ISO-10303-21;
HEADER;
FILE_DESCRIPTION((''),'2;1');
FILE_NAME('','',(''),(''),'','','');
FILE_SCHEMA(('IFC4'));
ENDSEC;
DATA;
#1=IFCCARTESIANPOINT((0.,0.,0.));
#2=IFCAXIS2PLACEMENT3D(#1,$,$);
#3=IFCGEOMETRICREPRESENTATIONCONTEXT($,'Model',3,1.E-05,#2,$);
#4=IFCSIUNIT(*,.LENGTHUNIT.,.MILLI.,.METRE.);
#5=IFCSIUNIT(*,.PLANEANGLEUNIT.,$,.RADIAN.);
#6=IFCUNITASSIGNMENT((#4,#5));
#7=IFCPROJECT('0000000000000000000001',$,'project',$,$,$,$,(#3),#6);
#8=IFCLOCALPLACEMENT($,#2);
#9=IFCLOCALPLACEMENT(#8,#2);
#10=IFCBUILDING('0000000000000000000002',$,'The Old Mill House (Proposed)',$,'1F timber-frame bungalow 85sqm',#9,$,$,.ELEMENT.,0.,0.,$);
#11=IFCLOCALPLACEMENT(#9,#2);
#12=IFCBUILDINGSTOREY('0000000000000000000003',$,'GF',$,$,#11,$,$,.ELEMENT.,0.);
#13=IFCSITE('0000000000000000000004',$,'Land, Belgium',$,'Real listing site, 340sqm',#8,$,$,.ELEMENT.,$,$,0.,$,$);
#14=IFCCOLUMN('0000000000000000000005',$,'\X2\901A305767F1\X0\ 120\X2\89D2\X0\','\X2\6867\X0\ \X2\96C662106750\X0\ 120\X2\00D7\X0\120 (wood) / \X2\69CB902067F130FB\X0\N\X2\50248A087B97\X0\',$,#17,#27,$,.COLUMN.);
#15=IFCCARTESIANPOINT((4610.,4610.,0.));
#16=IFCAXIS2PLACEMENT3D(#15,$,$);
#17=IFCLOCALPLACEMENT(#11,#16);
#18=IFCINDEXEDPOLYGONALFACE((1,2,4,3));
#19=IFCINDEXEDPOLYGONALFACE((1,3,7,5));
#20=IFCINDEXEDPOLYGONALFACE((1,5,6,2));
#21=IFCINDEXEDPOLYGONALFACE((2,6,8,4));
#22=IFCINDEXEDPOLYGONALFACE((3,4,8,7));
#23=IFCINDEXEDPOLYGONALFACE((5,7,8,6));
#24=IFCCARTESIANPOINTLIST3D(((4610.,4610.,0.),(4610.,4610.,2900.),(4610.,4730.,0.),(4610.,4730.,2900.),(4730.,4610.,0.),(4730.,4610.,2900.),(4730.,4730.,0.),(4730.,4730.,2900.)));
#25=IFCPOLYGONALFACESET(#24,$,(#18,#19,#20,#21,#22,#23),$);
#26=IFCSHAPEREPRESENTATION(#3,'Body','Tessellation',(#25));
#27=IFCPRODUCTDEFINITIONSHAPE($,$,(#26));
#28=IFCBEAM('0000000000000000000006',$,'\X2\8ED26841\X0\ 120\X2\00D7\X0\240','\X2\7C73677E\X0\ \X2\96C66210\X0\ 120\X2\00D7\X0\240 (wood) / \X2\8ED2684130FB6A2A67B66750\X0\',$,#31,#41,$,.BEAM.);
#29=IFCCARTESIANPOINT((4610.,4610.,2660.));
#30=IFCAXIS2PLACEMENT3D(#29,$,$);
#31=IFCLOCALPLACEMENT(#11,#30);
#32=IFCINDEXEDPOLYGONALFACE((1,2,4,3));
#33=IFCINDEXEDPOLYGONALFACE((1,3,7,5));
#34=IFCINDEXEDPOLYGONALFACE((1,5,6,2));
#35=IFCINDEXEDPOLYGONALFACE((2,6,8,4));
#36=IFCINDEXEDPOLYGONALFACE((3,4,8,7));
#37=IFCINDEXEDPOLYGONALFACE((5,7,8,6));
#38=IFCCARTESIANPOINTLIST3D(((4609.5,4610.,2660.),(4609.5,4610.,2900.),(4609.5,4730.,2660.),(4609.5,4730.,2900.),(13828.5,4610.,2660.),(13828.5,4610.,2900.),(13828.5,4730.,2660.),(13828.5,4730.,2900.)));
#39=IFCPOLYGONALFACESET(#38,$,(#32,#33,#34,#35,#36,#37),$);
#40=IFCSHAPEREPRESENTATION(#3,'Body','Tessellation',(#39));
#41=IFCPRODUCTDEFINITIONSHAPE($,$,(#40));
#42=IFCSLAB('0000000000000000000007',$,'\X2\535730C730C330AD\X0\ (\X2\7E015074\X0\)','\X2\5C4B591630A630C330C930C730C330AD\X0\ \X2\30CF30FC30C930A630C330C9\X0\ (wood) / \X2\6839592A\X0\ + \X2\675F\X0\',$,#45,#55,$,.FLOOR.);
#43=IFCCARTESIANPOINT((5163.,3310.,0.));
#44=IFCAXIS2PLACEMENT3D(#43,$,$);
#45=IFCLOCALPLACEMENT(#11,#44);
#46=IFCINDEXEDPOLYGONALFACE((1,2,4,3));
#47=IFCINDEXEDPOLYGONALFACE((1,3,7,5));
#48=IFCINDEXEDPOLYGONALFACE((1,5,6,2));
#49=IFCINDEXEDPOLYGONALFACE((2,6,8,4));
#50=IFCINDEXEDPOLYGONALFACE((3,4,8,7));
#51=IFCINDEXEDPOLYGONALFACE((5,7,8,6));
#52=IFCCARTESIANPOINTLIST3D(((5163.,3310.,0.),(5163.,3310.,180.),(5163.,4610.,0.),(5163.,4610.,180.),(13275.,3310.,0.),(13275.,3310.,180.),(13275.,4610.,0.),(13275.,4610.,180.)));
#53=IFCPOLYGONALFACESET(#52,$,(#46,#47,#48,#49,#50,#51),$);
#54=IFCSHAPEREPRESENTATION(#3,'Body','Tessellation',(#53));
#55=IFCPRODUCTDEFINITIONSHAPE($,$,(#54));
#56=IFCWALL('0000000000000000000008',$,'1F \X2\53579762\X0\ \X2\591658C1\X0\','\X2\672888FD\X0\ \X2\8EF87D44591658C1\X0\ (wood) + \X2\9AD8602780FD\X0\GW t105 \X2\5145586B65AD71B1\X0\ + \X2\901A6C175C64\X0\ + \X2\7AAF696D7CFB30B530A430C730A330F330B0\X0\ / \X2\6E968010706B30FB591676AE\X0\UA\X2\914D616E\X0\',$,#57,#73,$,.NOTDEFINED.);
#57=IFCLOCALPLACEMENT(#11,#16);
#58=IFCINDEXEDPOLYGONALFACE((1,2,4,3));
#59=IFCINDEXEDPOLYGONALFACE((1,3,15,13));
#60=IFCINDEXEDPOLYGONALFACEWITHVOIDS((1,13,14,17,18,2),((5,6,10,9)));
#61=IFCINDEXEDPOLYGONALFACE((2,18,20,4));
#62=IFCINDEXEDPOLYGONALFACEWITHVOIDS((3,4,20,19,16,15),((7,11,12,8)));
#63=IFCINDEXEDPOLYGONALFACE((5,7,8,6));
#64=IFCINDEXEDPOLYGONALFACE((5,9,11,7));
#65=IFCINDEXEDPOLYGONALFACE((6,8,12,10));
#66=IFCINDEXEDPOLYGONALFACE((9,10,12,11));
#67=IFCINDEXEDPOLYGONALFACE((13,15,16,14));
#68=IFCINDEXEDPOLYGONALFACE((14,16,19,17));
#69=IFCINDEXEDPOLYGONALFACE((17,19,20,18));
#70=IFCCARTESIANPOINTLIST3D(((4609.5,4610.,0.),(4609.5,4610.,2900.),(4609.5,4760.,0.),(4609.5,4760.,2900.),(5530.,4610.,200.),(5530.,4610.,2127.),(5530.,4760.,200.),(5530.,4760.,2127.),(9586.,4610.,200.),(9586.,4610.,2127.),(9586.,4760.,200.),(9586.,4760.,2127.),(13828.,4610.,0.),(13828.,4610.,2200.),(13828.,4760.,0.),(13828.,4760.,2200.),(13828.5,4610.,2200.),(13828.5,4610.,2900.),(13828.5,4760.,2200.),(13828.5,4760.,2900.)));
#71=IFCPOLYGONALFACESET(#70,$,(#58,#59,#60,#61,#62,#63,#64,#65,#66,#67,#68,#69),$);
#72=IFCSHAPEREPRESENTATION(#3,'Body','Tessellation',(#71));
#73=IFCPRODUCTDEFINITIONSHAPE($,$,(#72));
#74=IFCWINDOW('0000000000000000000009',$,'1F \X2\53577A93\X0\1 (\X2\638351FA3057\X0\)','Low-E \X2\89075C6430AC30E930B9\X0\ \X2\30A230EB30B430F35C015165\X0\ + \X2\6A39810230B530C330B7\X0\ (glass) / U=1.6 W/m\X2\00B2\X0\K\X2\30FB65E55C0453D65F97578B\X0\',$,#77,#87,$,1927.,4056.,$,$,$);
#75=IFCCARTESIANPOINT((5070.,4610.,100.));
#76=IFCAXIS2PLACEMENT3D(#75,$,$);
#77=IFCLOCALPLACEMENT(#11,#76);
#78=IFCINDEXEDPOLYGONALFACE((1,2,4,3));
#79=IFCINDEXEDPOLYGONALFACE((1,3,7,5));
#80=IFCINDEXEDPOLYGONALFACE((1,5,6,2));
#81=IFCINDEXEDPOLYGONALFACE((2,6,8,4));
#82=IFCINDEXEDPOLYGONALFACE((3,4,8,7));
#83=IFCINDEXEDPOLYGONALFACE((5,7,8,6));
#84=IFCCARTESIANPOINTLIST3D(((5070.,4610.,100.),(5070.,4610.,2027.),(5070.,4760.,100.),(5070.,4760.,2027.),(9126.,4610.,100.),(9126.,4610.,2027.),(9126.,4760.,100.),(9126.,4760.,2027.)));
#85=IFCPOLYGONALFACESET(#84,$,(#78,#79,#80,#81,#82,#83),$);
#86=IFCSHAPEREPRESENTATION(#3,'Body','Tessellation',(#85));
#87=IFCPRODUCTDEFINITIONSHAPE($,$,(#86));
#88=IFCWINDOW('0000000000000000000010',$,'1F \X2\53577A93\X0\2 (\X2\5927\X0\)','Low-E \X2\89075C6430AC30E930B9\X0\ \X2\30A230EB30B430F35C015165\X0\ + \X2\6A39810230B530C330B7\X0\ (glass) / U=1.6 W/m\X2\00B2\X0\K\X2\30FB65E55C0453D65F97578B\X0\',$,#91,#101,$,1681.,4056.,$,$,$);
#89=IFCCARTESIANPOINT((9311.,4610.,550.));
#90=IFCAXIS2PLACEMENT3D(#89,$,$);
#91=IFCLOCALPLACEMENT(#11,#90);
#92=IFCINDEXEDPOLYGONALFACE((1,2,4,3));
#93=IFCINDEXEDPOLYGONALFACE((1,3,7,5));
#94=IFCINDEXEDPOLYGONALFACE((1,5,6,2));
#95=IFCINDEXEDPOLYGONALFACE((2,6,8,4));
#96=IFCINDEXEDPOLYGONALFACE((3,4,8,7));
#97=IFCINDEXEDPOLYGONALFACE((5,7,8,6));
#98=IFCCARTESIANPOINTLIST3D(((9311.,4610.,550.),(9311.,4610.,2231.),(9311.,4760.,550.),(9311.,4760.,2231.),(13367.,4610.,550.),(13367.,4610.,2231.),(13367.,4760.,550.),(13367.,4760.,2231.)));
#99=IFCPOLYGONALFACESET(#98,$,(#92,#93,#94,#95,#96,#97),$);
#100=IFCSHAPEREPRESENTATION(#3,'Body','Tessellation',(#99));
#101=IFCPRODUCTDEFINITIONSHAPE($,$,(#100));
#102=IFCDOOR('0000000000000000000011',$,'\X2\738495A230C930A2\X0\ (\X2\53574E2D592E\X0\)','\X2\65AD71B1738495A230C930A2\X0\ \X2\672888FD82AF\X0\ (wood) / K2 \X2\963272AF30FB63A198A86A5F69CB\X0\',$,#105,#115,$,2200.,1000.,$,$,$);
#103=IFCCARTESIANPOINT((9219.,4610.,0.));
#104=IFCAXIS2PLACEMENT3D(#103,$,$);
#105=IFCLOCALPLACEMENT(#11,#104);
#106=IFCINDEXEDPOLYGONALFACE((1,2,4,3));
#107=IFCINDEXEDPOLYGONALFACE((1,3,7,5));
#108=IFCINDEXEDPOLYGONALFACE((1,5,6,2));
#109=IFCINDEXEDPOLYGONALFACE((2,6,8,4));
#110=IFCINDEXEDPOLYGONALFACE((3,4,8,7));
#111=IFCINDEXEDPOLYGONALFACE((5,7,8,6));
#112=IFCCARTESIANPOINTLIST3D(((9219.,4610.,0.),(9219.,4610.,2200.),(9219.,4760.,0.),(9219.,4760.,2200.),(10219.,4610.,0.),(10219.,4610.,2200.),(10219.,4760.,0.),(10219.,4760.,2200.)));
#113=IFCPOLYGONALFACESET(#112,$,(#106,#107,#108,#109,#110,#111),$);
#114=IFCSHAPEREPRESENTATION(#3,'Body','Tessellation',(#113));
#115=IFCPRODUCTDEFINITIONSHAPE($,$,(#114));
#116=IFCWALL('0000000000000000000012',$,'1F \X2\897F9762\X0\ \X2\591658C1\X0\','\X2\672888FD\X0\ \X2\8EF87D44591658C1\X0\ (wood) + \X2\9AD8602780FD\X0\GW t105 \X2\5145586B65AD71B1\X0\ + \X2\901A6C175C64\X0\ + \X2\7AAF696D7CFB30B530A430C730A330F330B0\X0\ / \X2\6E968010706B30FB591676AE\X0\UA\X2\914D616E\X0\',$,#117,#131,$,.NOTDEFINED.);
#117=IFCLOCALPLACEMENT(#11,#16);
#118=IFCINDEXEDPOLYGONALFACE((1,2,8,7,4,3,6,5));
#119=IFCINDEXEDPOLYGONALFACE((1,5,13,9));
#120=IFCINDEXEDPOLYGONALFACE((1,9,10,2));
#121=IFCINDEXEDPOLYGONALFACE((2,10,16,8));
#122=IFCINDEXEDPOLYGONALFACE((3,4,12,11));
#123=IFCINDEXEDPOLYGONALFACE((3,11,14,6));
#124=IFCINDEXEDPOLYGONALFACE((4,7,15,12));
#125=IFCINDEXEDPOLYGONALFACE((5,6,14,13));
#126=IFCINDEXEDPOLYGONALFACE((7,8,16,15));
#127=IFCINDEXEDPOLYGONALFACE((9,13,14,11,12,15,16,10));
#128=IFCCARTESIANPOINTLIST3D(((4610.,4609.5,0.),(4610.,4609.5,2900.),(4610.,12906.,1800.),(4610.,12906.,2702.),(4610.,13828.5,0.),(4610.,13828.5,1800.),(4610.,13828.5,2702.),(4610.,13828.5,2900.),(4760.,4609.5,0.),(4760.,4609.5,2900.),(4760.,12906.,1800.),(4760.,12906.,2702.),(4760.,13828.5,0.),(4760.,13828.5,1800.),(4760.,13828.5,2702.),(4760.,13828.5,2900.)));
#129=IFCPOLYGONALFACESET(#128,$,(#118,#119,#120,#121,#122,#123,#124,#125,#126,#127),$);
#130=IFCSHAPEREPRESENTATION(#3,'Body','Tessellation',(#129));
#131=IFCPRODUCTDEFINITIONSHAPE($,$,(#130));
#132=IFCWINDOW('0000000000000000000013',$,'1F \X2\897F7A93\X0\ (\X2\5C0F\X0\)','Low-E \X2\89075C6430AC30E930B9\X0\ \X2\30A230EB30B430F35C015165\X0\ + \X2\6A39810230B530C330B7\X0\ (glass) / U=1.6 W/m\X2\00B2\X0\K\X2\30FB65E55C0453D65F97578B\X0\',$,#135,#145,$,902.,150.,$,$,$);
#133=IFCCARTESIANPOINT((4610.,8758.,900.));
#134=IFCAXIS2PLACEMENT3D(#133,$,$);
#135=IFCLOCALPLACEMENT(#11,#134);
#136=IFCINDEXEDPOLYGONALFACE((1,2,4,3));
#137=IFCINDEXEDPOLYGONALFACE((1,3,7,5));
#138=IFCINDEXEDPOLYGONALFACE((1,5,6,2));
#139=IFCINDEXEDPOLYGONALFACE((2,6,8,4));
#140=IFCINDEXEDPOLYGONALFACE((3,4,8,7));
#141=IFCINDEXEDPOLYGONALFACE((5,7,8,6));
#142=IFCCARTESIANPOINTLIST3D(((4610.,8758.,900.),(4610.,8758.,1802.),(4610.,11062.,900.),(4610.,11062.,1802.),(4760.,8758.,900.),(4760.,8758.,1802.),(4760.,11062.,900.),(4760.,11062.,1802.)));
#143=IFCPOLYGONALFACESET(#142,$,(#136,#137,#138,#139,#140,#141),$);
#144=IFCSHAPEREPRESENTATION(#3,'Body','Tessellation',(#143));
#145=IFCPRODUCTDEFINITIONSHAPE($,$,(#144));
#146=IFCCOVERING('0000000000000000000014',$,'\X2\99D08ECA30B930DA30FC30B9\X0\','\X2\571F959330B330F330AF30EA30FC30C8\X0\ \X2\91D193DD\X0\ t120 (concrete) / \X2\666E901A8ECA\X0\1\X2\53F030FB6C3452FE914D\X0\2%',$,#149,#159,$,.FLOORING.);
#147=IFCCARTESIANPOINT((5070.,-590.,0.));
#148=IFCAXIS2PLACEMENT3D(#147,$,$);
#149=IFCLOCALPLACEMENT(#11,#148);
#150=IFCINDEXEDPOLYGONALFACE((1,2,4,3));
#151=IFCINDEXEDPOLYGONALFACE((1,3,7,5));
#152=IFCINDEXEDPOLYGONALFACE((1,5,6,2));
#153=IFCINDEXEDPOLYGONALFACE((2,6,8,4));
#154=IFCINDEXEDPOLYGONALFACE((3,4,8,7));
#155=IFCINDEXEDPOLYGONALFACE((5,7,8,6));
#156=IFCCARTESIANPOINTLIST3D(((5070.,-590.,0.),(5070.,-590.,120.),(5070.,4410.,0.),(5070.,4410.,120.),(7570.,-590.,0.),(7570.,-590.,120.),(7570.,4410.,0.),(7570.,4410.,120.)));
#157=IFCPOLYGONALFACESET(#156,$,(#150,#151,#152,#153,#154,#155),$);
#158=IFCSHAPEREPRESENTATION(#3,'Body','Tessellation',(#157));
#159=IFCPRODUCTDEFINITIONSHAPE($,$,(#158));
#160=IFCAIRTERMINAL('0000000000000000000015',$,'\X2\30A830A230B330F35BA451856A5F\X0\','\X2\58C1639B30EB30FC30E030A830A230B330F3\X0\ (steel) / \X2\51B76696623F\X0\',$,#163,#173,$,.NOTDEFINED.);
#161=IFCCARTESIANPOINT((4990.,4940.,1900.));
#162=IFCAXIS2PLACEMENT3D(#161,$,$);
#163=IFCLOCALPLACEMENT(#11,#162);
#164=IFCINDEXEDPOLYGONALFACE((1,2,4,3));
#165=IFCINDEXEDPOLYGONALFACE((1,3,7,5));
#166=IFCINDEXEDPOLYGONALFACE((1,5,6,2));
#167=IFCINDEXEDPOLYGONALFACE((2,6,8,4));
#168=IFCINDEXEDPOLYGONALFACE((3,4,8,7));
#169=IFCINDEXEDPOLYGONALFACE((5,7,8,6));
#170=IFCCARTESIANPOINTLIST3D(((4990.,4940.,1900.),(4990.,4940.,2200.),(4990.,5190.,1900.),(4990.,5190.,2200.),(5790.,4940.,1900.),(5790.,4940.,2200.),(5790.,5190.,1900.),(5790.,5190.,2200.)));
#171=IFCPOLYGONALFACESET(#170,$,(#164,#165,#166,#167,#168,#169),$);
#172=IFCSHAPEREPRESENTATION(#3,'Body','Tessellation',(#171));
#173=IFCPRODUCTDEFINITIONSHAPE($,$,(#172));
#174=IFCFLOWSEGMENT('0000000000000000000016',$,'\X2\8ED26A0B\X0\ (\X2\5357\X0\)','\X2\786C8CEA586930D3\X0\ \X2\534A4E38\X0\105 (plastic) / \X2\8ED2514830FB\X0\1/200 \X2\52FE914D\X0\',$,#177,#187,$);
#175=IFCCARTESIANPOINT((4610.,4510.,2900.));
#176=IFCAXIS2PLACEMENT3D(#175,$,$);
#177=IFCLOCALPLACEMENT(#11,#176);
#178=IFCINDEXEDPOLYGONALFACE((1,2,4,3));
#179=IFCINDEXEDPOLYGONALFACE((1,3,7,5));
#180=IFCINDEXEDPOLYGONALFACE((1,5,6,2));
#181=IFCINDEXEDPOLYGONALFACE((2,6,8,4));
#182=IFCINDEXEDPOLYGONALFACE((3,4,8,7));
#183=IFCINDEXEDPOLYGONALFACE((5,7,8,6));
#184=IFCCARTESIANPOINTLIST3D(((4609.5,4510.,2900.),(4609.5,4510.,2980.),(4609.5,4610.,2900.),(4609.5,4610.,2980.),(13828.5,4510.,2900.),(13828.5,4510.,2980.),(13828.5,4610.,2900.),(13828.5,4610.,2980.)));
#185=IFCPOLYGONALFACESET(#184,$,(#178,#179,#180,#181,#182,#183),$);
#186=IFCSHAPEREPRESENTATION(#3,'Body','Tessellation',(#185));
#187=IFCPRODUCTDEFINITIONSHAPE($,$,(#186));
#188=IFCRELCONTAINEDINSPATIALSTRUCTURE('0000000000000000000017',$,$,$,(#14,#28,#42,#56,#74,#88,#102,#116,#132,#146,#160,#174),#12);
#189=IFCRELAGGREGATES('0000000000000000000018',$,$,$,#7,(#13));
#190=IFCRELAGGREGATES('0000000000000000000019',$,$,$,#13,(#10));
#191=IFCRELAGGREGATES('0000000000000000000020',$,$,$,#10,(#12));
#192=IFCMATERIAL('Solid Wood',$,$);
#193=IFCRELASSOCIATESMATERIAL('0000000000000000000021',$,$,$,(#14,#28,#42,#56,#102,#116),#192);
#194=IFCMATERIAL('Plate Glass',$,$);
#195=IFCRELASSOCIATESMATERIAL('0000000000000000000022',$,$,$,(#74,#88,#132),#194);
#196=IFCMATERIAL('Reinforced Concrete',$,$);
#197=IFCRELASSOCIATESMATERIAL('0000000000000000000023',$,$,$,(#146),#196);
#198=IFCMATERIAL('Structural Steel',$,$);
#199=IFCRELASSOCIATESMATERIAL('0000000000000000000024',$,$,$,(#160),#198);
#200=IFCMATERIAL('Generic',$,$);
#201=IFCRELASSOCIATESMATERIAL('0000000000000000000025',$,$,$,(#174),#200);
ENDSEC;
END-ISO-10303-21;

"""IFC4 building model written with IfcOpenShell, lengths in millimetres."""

from ifc_helpers import new_model, si_unit, frame, frame_2d, origin, place, context, project, spatial, rectangle, extrude, material, element, fill, save


model = new_model("IFC4")

# Units and contexts
model_context = context("Model", 3, precision=1e-05, world=origin())
ifc_project = project(units=[si_unit("LENGTHUNIT", "METRE", prefix="MILLI"), si_unit("PLANEANGLEUNIT", "RADIAN")], contexts=[model_context])

# Site, building, storey
site_placement = place(None, origin())
site = spatial("IfcSite", under=ifc_project, at=site_placement, Name="Land, Belgium", ObjectType="Real listing site, 340sqm", CompositionType="ELEMENT", RefElevation=0.0)
building_placement = place(site_placement, origin())
building = spatial("IfcBuilding", under=site, at=building_placement, Name="The Old Mill House (Proposed)", ObjectType="1F timber-frame bungalow 85sqm", CompositionType="ELEMENT", ElevationOfRefHeight=0.0, ElevationOfTerrain=0.0)
storey_placement = place(building_placement, origin())
storey = spatial("IfcBuildingStorey", under=building, at=storey_placement, Name="GF", CompositionType="ELEMENT", Elevation=0.0)

# Column
ifc_material_1 = material(Name="Solid Wood")
column_1_placement = place(storey_placement, frame((4610.0, 4610.0, 0.0)))
element("IfcColumn", 1, at=column_1_placement, inside=storey, material=ifc_material_1, Name="通し柱 120角", Description="桧 集成材 120×120 (wood) / 構造柱・N値計算", PredefinedType="COLUMN", context=model_context, shape_type="SweptSolid", body=[
    extrude(rectangle(XDim=120.0, YDim=120.0, at=frame_2d((60.0, 60.0))), frame((4610.0, 4610.0, 0.0)), (0.0, 0.0, 1.0), 2900.0),
])

# Beam
beam_1_placement = place(storey_placement, frame((4610.0, 4610.0, 2660.0)))
element("IfcBeam", 2, at=beam_1_placement, inside=storey, material=ifc_material_1, Name="軒桁 120×240", Description="米松 集成 120×240 (wood) / 軒桁・横架材", PredefinedType="BEAM", context=model_context, shape_type="SweptSolid", body=[
    extrude(rectangle(XDim=9219.0, YDim=120.0, at=frame_2d((4609.0, 60.0))), frame((4610.0, 4610.0, 2660.0)), (0.0, 0.0, 1.0), 240.0),
])

# Slab
ifc_material_2 = material(Name="Reinforced Concrete")
slab_1_placement = place(storey_placement, frame((5163.0, 3310.0, 0.0)))
element("IfcSlab", 3, at=slab_1_placement, inside=storey, material=ifc_material_1, Name="南デッキ (縁側)", Description="屋外ウッドデッキ ハードウッド (wood) / 根太 + 束", PredefinedType="FLOOR", context=model_context, shape_type="SweptSolid", body=[
    extrude(rectangle(XDim=8112.0, YDim=1300.0, at=frame_2d((4056.0, 650.0))), frame((5163.0, 3310.0, 0.0)), (0.0, 0.0, 1.0), 180.0),
])

# Wall, openings, windows, door
wall_1_placement = place(storey_placement, frame((4610.0, 4610.0, 0.0)))
wall_1 = element("IfcWall", 4, at=wall_1_placement, inside=storey, material=ifc_material_1, Name="1F 南面 外壁", Description="木製 軸組外壁 (wood) + 高性能GW t105 充填断熱 + 通気層 + 窯業系サイディング / 準耐火・外皮UA配慮", PredefinedType="NOTDEFINED", context=model_context, shape_type="SweptSolid", body=[
    extrude(rectangle(XDim=9219.0, YDim=150.0, at=frame_2d((4609.0, 75.0))), frame((4610.0, 4610.0, 0.0)), (0.0, 0.0, 1.0), 2900.0),
])
opening_1_placement = place(storey_placement, frame((5070.0, 4610.0, 100.0)))
opening_1 = element("IfcOpeningElement", 5, at=opening_1_placement, cuts=wall_1, PredefinedType="NOTDEFINED", context=model_context, shape_type="SweptSolid", body=[
    extrude(rectangle(XDim=4056.0, YDim=150.0, at=frame_2d((2028.0, 75.0))), frame((5070.0, 4610.0, 100.0)), (0.0, 0.0, 1.0), 1927.0),
])
opening_2_placement = place(storey_placement, frame((9311.0, 4610.0, 550.0)))
opening_2 = element("IfcOpeningElement", 6, at=opening_2_placement, cuts=wall_1, PredefinedType="NOTDEFINED", context=model_context, shape_type="SweptSolid", body=[
    extrude(rectangle(XDim=4056.0, YDim=150.0, at=frame_2d((2028.0, 75.0))), frame((9311.0, 4610.0, 550.0)), (0.0, 0.0, 1.0), 1681.0),
])
opening_3_placement = place(storey_placement, frame((9219.0, 4610.0, 0.0)))
opening_3 = element("IfcOpeningElement", 7, at=opening_3_placement, cuts=wall_1, PredefinedType="NOTDEFINED", context=model_context, shape_type="SweptSolid", body=[
    extrude(rectangle(XDim=1000.0, YDim=150.0, at=frame_2d((500.0, 75.0))), frame((9219.0, 4610.0, 0.0)), (0.0, 0.0, 1.0), 2200.0),
])
ifc_material_3 = material(Name="Plate Glass")
window_1_placement = place(storey_placement, frame((5070.0, 4610.0, 100.0)))
window_1 = element("IfcWindow", 8, at=window_1_placement, inside=storey, material=ifc_material_3, Name="1F 南窓1 (掃出し)", Description="Low-E 複層ガラス アルゴン封入 + 樹脂サッシ (glass) / U=1.6 W/m²K・日射取得型", OverallHeight=1927.0, OverallWidth=4056.0, context=model_context, shape_type="SweptSolid", body=[
    extrude(rectangle(XDim=4056.0, YDim=150.0, at=frame_2d((2028.0, 75.0))), frame((5070.0, 4610.0, 100.0)), (0.0, 0.0, 1.0), 1927.0),
])
fill(opening_1, window_1)
window_2_placement = place(storey_placement, frame((9311.0, 4610.0, 550.0)))
window_2 = element("IfcWindow", 9, at=window_2_placement, inside=storey, material=ifc_material_3, Name="1F 南窓2 (大)", Description="Low-E 複層ガラス アルゴン封入 + 樹脂サッシ (glass) / U=1.6 W/m²K・日射取得型", OverallHeight=1681.0, OverallWidth=4056.0, context=model_context, shape_type="SweptSolid", body=[
    extrude(rectangle(XDim=4056.0, YDim=150.0, at=frame_2d((2028.0, 75.0))), frame((9311.0, 4610.0, 550.0)), (0.0, 0.0, 1.0), 1681.0),
])
fill(opening_2, window_2)
door_placement = place(storey_placement, frame((9219.0, 4610.0, 0.0)))
door = element("IfcDoor", 10, at=door_placement, inside=storey, material=ifc_material_1, Name="玄関ドア (南中央)", Description="断熱玄関ドア 木製芯 (wood) / K2 防犯・採風機構", OverallHeight=2200.0, OverallWidth=1000.0, context=model_context, shape_type="SweptSolid", body=[
    extrude(rectangle(XDim=1000.0, YDim=150.0, at=frame_2d((500.0, 75.0))), frame((9219.0, 4610.0, 0.0)), (0.0, 0.0, 1.0), 2200.0),
])
fill(opening_3, door)

# Wall, opening, window
wall_2_placement = place(storey_placement, frame((4610.0, 4610.0, 0.0)))
wall_2 = element("IfcWall", 11, at=wall_2_placement, inside=storey, material=ifc_material_1, Name="1F 西面 外壁", Description="木製 軸組外壁 (wood) + 高性能GW t105 充填断熱 + 通気層 + 窯業系サイディング / 準耐火・外皮UA配慮", PredefinedType="NOTDEFINED", context=model_context, shape_type="SweptSolid", body=[
    extrude(rectangle(XDim=150.0, YDim=9219.0, at=frame_2d((75.0, 4609.0))), frame((4610.0, 4610.0, 0.0)), (0.0, 0.0, 1.0), 2900.0),
])
opening_4_placement = place(storey_placement, frame((4610.0, 8758.0, 900.0)))
opening_4 = element("IfcOpeningElement", 12, at=opening_4_placement, cuts=wall_2, PredefinedType="NOTDEFINED", context=model_context, shape_type="SweptSolid", body=[
    extrude(rectangle(XDim=150.0, YDim=2304.0, at=frame_2d((75.0, 1152.0))), frame((4610.0, 8758.0, 900.0)), (0.0, 0.0, 1.0), 902.0),
])
window_3_placement = place(storey_placement, frame((4610.0, 8758.0, 900.0)))
window_3 = element("IfcWindow", 13, at=window_3_placement, inside=storey, material=ifc_material_3, Name="1F 西窓 (小)", Description="Low-E 複層ガラス アルゴン封入 + 樹脂サッシ (glass) / U=1.6 W/m²K・日射取得型", OverallHeight=902.0, OverallWidth=150.0, context=model_context, shape_type="SweptSolid", body=[
    extrude(rectangle(XDim=150.0, YDim=2304.0, at=frame_2d((75.0, 1152.0))), frame((4610.0, 8758.0, 900.0)), (0.0, 0.0, 1.0), 902.0),
])
fill(opening_4, window_3)

# Shared definitions
ifc_material_4 = material(Name="Structural Steel")

# Covering
ifc_material_5 = material(Name="Generic")
covering_1_placement = place(storey_placement, frame((5070.0, -590.0, 0.0)))
element("IfcCovering", 14, at=covering_1_placement, inside=storey, material=ifc_material_2, Name="駐車スペース", Description="土間コンクリート 金鏝 t120 (concrete) / 普通車1台・水勾配2%", PredefinedType="FLOORING", context=model_context, shape_type="SweptSolid", body=[
    extrude(rectangle(XDim=2500.0, YDim=5000.0, at=frame_2d((1250.0, 2500.0))), frame((5070.0, -590.0, 0.0)), (0.0, 0.0, 1.0), 120.0),
])

# Air terminal
air_terminal_placement = place(storey_placement, frame((4990.0, 4940.0, 1900.0)))
element("IfcAirTerminal", 15, at=air_terminal_placement, inside=storey, material=ifc_material_4, Name="エアコン室内機", Description="壁掛ルームエアコン (steel) / 冷暖房", PredefinedType="NOTDEFINED", context=model_context, shape_type="SweptSolid", body=[
    extrude(rectangle(XDim=800.0, YDim=250.0, at=frame_2d((400.0, 125.0))), frame((4990.0, 4940.0, 1900.0)), (0.0, 0.0, 1.0), 300.0),
])

# Flow segment
flow_segment_1_placement = place(storey_placement, frame((4610.0, 4510.0, 2900.0)))
element("IfcFlowSegment", 16, at=flow_segment_1_placement, inside=storey, material=ifc_material_5, Name="軒樋 (南)", Description="硬質塩ビ 半丸105 (plastic) / 軒先・1/200 勾配", context=model_context, shape_type="SweptSolid", body=[
    extrude(rectangle(XDim=9219.0, YDim=100.0, at=frame_2d((4609.0, 50.0))), frame((4610.0, 4510.0, 2900.0)), (0.0, 0.0, 1.0), 80.0),
])

save(model, "model.ifc")
